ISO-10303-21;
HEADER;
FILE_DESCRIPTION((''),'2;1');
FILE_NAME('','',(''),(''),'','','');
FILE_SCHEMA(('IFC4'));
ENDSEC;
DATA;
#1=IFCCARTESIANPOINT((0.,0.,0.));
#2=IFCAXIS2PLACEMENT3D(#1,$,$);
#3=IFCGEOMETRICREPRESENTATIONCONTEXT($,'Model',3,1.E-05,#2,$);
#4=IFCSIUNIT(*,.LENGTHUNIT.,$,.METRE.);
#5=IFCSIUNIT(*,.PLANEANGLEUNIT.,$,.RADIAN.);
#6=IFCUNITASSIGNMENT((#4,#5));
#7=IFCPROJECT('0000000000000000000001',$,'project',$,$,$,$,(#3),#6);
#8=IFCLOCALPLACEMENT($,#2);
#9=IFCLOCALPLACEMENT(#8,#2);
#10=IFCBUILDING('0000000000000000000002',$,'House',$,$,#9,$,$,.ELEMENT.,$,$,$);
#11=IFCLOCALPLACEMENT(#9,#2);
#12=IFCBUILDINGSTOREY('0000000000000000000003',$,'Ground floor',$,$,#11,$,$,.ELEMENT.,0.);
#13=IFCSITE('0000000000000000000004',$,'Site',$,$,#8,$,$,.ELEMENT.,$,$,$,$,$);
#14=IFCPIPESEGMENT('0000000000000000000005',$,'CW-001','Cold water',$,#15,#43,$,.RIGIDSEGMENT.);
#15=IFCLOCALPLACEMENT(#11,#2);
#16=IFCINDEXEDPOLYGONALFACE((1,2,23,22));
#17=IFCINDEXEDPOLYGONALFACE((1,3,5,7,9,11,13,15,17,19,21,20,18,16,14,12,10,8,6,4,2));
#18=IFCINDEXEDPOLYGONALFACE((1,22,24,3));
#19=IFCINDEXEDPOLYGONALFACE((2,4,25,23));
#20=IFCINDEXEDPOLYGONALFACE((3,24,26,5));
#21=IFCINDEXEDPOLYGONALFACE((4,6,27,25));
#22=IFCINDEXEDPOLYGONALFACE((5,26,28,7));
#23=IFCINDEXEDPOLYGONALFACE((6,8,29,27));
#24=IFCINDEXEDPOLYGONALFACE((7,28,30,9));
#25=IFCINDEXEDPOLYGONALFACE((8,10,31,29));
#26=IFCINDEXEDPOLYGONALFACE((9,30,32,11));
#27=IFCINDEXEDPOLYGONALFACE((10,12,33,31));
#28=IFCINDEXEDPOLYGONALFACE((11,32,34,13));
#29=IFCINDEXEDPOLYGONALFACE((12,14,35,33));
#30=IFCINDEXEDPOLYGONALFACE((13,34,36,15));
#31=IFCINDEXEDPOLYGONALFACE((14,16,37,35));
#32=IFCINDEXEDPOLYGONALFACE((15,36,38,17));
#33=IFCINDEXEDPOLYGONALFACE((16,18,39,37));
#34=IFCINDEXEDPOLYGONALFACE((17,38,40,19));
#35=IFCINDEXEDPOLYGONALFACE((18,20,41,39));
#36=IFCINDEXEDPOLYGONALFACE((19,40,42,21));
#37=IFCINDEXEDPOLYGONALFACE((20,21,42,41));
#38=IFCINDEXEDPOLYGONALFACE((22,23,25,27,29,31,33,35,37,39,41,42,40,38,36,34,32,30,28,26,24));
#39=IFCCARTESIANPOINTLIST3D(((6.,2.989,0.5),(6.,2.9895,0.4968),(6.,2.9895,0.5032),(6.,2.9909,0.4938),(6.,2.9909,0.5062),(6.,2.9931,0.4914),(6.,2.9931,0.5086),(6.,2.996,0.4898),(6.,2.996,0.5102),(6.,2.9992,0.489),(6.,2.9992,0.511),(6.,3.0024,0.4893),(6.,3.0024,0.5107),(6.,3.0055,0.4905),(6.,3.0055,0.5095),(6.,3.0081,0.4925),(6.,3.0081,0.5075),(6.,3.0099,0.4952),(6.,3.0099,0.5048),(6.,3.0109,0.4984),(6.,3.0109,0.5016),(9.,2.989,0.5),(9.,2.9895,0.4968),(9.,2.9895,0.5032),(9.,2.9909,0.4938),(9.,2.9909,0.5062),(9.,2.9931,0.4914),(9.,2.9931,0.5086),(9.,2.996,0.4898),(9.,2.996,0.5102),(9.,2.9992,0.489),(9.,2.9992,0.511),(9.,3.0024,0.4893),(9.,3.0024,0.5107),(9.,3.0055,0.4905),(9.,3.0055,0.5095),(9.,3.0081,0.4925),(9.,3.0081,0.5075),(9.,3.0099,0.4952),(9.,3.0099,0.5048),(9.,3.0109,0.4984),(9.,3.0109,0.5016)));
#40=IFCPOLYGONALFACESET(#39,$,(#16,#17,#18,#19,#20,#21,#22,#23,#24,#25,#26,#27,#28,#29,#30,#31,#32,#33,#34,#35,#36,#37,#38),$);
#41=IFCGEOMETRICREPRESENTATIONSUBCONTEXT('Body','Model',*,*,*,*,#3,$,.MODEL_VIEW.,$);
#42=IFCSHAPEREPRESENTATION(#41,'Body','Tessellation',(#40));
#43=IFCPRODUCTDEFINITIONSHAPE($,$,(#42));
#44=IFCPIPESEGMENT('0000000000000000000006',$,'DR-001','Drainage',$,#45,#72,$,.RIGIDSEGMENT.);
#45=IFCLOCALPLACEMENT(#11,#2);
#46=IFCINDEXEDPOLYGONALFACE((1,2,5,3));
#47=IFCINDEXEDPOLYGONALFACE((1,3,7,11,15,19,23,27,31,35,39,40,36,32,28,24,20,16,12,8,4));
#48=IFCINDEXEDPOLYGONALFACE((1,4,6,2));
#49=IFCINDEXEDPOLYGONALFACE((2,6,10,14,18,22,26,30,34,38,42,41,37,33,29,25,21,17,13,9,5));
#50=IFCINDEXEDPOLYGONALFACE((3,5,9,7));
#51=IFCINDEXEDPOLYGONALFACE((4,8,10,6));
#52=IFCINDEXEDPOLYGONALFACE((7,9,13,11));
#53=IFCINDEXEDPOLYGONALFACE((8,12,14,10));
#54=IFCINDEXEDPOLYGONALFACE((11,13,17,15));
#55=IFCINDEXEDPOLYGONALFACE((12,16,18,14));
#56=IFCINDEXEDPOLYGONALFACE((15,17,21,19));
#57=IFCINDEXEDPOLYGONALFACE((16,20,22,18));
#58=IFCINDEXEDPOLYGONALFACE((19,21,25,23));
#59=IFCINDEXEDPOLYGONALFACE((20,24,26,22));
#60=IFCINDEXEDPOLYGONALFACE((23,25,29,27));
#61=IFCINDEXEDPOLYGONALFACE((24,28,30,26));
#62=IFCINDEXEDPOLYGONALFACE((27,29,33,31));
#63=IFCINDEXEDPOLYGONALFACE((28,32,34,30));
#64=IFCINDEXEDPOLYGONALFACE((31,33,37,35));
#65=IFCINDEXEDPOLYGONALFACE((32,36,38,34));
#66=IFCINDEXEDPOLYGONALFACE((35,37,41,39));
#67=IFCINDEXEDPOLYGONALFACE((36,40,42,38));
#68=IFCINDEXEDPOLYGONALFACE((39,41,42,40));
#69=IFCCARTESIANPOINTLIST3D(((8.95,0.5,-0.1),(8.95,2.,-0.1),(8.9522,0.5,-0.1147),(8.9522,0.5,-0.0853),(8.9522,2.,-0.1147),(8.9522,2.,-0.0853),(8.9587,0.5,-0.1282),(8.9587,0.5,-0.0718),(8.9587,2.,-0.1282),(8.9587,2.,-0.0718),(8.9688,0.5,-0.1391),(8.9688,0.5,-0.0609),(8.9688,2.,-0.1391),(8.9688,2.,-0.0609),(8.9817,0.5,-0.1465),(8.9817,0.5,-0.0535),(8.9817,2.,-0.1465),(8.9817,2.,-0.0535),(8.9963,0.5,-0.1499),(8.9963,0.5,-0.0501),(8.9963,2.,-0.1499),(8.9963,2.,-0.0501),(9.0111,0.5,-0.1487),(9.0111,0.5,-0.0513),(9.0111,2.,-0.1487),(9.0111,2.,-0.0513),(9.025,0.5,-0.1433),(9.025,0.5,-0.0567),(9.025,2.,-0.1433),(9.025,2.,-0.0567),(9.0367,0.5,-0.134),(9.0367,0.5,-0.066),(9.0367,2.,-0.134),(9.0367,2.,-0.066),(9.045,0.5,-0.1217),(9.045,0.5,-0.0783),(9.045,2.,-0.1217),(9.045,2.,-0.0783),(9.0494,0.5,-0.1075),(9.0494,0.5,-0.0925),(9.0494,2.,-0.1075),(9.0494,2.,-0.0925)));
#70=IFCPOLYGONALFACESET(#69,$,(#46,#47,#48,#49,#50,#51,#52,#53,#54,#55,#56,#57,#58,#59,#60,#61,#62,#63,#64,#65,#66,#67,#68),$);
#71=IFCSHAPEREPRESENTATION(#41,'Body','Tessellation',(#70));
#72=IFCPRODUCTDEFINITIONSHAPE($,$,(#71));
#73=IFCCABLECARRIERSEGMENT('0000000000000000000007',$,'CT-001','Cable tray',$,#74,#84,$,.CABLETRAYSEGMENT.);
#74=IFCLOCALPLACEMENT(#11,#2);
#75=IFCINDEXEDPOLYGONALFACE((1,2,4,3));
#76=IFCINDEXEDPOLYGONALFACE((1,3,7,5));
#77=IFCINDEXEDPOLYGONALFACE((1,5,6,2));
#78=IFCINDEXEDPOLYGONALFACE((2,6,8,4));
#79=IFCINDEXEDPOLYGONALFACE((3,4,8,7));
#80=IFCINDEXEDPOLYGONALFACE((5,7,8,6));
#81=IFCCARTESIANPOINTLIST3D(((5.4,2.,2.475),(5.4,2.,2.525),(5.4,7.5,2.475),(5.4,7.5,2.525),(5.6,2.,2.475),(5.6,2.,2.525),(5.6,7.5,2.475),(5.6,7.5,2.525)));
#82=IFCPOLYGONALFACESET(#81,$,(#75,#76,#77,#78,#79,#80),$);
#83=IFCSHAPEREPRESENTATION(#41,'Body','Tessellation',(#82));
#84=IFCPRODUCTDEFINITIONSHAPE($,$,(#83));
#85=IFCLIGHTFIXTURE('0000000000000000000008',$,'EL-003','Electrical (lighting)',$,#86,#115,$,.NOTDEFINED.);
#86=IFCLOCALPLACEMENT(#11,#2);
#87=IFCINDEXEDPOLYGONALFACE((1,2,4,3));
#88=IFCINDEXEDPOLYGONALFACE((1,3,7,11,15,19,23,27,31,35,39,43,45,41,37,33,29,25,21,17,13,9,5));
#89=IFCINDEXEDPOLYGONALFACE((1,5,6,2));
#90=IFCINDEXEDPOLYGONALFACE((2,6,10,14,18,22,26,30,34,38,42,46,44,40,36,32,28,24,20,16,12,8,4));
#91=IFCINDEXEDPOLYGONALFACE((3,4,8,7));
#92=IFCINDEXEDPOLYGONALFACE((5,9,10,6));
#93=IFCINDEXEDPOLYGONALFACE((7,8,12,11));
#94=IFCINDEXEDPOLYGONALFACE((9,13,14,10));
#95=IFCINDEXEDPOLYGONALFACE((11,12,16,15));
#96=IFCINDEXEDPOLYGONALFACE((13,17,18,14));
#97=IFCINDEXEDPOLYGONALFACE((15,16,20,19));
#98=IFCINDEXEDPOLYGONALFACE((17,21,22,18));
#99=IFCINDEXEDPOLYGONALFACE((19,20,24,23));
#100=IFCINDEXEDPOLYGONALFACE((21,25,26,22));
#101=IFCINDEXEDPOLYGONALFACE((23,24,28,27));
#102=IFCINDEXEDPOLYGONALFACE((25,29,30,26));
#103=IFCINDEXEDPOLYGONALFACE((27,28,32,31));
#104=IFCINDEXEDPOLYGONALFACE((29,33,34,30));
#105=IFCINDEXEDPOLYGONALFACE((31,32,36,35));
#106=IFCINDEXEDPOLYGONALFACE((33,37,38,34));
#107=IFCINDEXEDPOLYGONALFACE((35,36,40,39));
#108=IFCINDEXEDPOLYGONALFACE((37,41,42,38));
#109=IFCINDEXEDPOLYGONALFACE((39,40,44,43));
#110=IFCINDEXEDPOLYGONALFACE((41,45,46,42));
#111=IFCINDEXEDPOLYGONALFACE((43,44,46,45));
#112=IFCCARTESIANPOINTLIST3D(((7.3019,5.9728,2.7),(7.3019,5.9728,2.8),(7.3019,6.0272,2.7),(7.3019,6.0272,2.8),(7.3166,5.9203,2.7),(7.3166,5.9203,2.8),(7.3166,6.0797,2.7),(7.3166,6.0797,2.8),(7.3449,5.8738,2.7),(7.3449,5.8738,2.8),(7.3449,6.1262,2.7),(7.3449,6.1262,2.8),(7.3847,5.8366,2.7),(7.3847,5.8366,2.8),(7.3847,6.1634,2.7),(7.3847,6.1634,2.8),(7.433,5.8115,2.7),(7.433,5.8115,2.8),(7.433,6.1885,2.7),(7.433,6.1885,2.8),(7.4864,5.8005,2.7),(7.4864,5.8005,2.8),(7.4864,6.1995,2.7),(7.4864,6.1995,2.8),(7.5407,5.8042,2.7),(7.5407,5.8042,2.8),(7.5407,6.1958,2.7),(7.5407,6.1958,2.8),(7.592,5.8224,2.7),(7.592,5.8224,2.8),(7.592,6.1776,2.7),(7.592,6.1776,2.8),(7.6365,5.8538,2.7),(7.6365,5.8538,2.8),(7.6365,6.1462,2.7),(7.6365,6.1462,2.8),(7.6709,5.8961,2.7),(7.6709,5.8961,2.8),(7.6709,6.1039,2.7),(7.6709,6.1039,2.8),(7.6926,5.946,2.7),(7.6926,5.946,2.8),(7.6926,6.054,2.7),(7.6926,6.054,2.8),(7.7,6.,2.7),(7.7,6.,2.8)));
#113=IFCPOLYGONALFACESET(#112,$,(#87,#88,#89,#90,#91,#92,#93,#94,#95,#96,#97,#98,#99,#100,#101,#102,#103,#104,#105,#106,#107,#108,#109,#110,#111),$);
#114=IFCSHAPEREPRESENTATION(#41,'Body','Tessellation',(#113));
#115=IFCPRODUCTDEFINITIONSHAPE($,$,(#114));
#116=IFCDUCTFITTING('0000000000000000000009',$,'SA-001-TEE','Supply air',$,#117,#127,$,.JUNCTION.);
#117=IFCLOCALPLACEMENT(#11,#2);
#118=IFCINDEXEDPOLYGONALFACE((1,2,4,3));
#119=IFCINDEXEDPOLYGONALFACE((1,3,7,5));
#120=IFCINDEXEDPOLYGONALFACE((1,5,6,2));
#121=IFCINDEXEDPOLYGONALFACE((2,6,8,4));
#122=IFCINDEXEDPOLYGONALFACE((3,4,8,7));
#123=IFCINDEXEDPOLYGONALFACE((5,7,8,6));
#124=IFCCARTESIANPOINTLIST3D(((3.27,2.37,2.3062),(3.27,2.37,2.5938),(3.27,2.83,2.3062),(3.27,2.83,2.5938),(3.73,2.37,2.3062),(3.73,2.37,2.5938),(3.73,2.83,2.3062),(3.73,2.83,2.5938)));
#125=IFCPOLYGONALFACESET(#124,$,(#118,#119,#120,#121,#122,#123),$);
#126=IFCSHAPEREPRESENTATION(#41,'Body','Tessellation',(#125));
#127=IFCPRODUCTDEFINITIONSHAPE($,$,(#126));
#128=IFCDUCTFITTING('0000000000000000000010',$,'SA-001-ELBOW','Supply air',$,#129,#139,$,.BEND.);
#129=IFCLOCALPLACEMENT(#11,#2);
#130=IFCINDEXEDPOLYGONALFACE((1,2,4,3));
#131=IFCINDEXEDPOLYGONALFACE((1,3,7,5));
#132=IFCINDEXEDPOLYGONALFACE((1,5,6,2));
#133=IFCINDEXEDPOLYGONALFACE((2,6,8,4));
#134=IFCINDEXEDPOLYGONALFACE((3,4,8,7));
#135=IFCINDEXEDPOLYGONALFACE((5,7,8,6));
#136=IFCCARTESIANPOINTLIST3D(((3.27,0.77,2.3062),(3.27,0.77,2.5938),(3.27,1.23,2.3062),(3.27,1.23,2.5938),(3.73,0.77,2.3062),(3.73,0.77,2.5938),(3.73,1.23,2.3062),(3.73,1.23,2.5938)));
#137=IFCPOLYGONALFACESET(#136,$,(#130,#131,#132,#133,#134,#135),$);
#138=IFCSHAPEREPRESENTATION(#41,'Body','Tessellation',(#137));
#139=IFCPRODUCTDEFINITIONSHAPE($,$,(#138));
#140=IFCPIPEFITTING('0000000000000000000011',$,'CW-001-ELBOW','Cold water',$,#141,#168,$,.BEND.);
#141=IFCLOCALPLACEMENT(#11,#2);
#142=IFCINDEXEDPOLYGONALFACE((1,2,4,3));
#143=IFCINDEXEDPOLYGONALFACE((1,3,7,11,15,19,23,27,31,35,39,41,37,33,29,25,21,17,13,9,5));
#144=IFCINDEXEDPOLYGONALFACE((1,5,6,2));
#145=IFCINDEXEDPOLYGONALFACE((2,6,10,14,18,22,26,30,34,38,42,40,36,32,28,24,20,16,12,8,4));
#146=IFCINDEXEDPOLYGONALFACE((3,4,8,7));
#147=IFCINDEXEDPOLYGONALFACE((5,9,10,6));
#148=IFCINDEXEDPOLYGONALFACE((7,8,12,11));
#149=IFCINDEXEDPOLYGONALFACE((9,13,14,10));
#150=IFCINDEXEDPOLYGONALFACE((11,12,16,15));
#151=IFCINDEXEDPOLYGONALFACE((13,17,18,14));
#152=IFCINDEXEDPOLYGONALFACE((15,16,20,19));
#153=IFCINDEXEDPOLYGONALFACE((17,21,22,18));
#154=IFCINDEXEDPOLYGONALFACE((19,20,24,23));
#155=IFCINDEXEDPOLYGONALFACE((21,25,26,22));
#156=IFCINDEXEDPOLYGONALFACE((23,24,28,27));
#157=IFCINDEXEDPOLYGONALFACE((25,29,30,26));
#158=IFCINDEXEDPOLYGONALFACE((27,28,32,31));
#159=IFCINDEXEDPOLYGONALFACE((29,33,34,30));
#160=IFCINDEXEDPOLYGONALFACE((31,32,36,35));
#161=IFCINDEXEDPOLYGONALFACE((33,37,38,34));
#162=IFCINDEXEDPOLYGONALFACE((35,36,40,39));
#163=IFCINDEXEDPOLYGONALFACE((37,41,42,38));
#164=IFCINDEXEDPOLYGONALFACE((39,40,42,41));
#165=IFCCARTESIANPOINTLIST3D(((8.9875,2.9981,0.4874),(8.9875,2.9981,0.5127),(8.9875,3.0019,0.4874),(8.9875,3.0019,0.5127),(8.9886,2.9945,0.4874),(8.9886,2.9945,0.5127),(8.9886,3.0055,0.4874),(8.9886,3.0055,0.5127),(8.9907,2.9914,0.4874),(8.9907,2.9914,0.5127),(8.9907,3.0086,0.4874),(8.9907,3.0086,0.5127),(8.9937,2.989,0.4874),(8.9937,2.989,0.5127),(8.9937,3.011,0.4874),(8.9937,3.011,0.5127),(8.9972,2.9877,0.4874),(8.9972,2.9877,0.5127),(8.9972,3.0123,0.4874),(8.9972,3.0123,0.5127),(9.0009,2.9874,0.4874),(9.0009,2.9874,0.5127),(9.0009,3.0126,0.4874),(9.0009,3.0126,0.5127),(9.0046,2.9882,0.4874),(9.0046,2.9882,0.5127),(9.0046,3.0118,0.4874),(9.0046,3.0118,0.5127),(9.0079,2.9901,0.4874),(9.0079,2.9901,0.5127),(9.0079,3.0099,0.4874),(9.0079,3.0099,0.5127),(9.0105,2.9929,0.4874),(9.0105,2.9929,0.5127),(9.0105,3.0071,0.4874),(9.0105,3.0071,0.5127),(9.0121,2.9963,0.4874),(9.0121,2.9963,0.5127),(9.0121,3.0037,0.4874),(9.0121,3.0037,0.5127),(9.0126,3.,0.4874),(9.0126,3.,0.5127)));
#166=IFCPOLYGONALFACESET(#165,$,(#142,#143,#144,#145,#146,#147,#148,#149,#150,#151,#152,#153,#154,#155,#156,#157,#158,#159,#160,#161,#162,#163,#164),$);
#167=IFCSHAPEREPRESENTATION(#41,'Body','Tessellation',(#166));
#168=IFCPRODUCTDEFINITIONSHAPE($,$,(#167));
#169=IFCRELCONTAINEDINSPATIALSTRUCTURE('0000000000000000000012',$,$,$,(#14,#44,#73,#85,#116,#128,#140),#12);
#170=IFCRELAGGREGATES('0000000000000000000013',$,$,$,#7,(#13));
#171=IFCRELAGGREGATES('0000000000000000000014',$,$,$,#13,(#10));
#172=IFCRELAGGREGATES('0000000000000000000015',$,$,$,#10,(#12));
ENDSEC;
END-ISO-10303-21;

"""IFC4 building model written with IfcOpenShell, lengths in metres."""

from ifc_helpers import new_model, si_unit, frame, origin, origin_2d, place, context, subcontext, project, spatial, rectangle, circle, extrude, element, save


model = new_model("IFC4")

# Units and contexts
model_context = context("Model", 3, precision=1e-05, world=origin())
body_context = subcontext(model_context, "Body", "Model", "MODEL_VIEW")
ifc_project = project(units=[si_unit("LENGTHUNIT", "METRE"), si_unit("PLANEANGLEUNIT", "RADIAN")], contexts=[model_context])

# Site, building, storey
site_placement = place(None, origin())
site = spatial("IfcSite", under=ifc_project, at=site_placement, Name="Site", CompositionType="ELEMENT")
building_placement = place(site_placement, origin())
building = spatial("IfcBuilding", under=site, at=building_placement, Name="House", CompositionType="ELEMENT")
storey_placement = place(building_placement, origin())
storey = spatial("IfcBuildingStorey", under=building, at=storey_placement, Name="Ground floor", CompositionType="ELEMENT", Elevation=0.0)

# Pipe segments
pipe_segment_1_placement = place(storey_placement, frame((9.0, 3.0, 0.5), z_axis=(-1.0, 0.0, 0.0), x_axis=(0.0, -1.0, 0.0)))
element("IfcPipeSegment", 1, at=pipe_segment_1_placement, inside=storey, Name="CW-001", Description="Cold water", PredefinedType="RIGIDSEGMENT", context=body_context, shape_type="SweptSolid", body=[
    extrude(circle(Radius=0.011, at=origin_2d()), origin(), (0.0, 0.0, 1.0), 3.0),
])
pipe_segment_2_placement = place(storey_placement, frame((9.0, 0.5, -0.1), z_axis=(0.0, 1.0, 0.0), x_axis=(-1.0, 0.0, 0.0)))
element("IfcPipeSegment", 2, at=pipe_segment_2_placement, inside=storey, Name="DR-001", Description="Drainage", PredefinedType="RIGIDSEGMENT", context=body_context, shape_type="SweptSolid", body=[
    extrude(circle(Radius=0.05, at=origin_2d()), origin(), (0.0, 0.0, 1.0), 1.5),
])

# Cable carrier segment
cable_carrier_segment_placement = place(storey_placement, frame((5.5, 2.0, 2.5), z_axis=(0.0, 1.0, 0.0), x_axis=(-1.0, 0.0, 0.0)))
element("IfcCableCarrierSegment", 3, at=cable_carrier_segment_placement, inside=storey, Name="CT-001", Description="Cable tray", PredefinedType="CABLETRAYSEGMENT", context=body_context, shape_type="SweptSolid", body=[
    extrude(rectangle(XDim=0.2, YDim=0.05, at=origin_2d()), origin(), (0.0, 0.0, 1.0), 5.5),
])

# Light fixture
light_fixture_placement = place(storey_placement, frame((7.5, 6.0, 2.7), z_axis=(0.0, 0.0, 1.0), x_axis=(1.0, 0.0, 0.0)))
element("IfcLightFixture", 4, at=light_fixture_placement, inside=storey, Name="EL-003", Description="Electrical (lighting)", PredefinedType="NOTDEFINED", context=body_context, shape_type="SweptSolid", body=[
    extrude(circle(Radius=0.2, at=origin_2d()), origin(), (0.0, 0.0, 1.0), 0.1),
])

# Duct fittings
duct_fitting_1_placement = place(storey_placement, frame((3.5, 2.6, 2.3062), z_axis=(0.0, 0.0, 1.0), x_axis=(1.0, 0.0, 0.0)))
element("IfcDuctFitting", 5, at=duct_fitting_1_placement, inside=storey, Name="SA-001-TEE", Description="Supply air", PredefinedType="JUNCTION", context=body_context, shape_type="SweptSolid", body=[
    extrude(rectangle(XDim=0.46, YDim=0.46, at=origin_2d()), origin(), (0.0, 0.0, 1.0), 0.2875),
])
duct_fitting_2_placement = place(storey_placement, frame((3.5, 1.0, 2.3062), z_axis=(0.0, 0.0, 1.0), x_axis=(1.0, 0.0, 0.0)))
element("IfcDuctFitting", 6, at=duct_fitting_2_placement, inside=storey, Name="SA-001-ELBOW", Description="Supply air", PredefinedType="BEND", context=body_context, shape_type="SweptSolid", body=[
    extrude(rectangle(XDim=0.46, YDim=0.46, at=origin_2d()), origin(), (0.0, 0.0, 1.0), 0.2875),
])

# Pipe fitting
pipe_fitting_placement = place(storey_placement, frame((9.0, 3.0, 0.4874), z_axis=(0.0, 0.0, 1.0), x_axis=(1.0, 0.0, 0.0)))
element("IfcPipeFitting", 7, at=pipe_fitting_placement, inside=storey, Name="CW-001-ELBOW", Description="Cold water", PredefinedType="BEND", context=body_context, shape_type="SweptSolid", body=[
    extrude(circle(Radius=0.0126, at=origin_2d()), origin(), (0.0, 0.0, 1.0), 0.0253),
])

save(model, "model.ifc")
